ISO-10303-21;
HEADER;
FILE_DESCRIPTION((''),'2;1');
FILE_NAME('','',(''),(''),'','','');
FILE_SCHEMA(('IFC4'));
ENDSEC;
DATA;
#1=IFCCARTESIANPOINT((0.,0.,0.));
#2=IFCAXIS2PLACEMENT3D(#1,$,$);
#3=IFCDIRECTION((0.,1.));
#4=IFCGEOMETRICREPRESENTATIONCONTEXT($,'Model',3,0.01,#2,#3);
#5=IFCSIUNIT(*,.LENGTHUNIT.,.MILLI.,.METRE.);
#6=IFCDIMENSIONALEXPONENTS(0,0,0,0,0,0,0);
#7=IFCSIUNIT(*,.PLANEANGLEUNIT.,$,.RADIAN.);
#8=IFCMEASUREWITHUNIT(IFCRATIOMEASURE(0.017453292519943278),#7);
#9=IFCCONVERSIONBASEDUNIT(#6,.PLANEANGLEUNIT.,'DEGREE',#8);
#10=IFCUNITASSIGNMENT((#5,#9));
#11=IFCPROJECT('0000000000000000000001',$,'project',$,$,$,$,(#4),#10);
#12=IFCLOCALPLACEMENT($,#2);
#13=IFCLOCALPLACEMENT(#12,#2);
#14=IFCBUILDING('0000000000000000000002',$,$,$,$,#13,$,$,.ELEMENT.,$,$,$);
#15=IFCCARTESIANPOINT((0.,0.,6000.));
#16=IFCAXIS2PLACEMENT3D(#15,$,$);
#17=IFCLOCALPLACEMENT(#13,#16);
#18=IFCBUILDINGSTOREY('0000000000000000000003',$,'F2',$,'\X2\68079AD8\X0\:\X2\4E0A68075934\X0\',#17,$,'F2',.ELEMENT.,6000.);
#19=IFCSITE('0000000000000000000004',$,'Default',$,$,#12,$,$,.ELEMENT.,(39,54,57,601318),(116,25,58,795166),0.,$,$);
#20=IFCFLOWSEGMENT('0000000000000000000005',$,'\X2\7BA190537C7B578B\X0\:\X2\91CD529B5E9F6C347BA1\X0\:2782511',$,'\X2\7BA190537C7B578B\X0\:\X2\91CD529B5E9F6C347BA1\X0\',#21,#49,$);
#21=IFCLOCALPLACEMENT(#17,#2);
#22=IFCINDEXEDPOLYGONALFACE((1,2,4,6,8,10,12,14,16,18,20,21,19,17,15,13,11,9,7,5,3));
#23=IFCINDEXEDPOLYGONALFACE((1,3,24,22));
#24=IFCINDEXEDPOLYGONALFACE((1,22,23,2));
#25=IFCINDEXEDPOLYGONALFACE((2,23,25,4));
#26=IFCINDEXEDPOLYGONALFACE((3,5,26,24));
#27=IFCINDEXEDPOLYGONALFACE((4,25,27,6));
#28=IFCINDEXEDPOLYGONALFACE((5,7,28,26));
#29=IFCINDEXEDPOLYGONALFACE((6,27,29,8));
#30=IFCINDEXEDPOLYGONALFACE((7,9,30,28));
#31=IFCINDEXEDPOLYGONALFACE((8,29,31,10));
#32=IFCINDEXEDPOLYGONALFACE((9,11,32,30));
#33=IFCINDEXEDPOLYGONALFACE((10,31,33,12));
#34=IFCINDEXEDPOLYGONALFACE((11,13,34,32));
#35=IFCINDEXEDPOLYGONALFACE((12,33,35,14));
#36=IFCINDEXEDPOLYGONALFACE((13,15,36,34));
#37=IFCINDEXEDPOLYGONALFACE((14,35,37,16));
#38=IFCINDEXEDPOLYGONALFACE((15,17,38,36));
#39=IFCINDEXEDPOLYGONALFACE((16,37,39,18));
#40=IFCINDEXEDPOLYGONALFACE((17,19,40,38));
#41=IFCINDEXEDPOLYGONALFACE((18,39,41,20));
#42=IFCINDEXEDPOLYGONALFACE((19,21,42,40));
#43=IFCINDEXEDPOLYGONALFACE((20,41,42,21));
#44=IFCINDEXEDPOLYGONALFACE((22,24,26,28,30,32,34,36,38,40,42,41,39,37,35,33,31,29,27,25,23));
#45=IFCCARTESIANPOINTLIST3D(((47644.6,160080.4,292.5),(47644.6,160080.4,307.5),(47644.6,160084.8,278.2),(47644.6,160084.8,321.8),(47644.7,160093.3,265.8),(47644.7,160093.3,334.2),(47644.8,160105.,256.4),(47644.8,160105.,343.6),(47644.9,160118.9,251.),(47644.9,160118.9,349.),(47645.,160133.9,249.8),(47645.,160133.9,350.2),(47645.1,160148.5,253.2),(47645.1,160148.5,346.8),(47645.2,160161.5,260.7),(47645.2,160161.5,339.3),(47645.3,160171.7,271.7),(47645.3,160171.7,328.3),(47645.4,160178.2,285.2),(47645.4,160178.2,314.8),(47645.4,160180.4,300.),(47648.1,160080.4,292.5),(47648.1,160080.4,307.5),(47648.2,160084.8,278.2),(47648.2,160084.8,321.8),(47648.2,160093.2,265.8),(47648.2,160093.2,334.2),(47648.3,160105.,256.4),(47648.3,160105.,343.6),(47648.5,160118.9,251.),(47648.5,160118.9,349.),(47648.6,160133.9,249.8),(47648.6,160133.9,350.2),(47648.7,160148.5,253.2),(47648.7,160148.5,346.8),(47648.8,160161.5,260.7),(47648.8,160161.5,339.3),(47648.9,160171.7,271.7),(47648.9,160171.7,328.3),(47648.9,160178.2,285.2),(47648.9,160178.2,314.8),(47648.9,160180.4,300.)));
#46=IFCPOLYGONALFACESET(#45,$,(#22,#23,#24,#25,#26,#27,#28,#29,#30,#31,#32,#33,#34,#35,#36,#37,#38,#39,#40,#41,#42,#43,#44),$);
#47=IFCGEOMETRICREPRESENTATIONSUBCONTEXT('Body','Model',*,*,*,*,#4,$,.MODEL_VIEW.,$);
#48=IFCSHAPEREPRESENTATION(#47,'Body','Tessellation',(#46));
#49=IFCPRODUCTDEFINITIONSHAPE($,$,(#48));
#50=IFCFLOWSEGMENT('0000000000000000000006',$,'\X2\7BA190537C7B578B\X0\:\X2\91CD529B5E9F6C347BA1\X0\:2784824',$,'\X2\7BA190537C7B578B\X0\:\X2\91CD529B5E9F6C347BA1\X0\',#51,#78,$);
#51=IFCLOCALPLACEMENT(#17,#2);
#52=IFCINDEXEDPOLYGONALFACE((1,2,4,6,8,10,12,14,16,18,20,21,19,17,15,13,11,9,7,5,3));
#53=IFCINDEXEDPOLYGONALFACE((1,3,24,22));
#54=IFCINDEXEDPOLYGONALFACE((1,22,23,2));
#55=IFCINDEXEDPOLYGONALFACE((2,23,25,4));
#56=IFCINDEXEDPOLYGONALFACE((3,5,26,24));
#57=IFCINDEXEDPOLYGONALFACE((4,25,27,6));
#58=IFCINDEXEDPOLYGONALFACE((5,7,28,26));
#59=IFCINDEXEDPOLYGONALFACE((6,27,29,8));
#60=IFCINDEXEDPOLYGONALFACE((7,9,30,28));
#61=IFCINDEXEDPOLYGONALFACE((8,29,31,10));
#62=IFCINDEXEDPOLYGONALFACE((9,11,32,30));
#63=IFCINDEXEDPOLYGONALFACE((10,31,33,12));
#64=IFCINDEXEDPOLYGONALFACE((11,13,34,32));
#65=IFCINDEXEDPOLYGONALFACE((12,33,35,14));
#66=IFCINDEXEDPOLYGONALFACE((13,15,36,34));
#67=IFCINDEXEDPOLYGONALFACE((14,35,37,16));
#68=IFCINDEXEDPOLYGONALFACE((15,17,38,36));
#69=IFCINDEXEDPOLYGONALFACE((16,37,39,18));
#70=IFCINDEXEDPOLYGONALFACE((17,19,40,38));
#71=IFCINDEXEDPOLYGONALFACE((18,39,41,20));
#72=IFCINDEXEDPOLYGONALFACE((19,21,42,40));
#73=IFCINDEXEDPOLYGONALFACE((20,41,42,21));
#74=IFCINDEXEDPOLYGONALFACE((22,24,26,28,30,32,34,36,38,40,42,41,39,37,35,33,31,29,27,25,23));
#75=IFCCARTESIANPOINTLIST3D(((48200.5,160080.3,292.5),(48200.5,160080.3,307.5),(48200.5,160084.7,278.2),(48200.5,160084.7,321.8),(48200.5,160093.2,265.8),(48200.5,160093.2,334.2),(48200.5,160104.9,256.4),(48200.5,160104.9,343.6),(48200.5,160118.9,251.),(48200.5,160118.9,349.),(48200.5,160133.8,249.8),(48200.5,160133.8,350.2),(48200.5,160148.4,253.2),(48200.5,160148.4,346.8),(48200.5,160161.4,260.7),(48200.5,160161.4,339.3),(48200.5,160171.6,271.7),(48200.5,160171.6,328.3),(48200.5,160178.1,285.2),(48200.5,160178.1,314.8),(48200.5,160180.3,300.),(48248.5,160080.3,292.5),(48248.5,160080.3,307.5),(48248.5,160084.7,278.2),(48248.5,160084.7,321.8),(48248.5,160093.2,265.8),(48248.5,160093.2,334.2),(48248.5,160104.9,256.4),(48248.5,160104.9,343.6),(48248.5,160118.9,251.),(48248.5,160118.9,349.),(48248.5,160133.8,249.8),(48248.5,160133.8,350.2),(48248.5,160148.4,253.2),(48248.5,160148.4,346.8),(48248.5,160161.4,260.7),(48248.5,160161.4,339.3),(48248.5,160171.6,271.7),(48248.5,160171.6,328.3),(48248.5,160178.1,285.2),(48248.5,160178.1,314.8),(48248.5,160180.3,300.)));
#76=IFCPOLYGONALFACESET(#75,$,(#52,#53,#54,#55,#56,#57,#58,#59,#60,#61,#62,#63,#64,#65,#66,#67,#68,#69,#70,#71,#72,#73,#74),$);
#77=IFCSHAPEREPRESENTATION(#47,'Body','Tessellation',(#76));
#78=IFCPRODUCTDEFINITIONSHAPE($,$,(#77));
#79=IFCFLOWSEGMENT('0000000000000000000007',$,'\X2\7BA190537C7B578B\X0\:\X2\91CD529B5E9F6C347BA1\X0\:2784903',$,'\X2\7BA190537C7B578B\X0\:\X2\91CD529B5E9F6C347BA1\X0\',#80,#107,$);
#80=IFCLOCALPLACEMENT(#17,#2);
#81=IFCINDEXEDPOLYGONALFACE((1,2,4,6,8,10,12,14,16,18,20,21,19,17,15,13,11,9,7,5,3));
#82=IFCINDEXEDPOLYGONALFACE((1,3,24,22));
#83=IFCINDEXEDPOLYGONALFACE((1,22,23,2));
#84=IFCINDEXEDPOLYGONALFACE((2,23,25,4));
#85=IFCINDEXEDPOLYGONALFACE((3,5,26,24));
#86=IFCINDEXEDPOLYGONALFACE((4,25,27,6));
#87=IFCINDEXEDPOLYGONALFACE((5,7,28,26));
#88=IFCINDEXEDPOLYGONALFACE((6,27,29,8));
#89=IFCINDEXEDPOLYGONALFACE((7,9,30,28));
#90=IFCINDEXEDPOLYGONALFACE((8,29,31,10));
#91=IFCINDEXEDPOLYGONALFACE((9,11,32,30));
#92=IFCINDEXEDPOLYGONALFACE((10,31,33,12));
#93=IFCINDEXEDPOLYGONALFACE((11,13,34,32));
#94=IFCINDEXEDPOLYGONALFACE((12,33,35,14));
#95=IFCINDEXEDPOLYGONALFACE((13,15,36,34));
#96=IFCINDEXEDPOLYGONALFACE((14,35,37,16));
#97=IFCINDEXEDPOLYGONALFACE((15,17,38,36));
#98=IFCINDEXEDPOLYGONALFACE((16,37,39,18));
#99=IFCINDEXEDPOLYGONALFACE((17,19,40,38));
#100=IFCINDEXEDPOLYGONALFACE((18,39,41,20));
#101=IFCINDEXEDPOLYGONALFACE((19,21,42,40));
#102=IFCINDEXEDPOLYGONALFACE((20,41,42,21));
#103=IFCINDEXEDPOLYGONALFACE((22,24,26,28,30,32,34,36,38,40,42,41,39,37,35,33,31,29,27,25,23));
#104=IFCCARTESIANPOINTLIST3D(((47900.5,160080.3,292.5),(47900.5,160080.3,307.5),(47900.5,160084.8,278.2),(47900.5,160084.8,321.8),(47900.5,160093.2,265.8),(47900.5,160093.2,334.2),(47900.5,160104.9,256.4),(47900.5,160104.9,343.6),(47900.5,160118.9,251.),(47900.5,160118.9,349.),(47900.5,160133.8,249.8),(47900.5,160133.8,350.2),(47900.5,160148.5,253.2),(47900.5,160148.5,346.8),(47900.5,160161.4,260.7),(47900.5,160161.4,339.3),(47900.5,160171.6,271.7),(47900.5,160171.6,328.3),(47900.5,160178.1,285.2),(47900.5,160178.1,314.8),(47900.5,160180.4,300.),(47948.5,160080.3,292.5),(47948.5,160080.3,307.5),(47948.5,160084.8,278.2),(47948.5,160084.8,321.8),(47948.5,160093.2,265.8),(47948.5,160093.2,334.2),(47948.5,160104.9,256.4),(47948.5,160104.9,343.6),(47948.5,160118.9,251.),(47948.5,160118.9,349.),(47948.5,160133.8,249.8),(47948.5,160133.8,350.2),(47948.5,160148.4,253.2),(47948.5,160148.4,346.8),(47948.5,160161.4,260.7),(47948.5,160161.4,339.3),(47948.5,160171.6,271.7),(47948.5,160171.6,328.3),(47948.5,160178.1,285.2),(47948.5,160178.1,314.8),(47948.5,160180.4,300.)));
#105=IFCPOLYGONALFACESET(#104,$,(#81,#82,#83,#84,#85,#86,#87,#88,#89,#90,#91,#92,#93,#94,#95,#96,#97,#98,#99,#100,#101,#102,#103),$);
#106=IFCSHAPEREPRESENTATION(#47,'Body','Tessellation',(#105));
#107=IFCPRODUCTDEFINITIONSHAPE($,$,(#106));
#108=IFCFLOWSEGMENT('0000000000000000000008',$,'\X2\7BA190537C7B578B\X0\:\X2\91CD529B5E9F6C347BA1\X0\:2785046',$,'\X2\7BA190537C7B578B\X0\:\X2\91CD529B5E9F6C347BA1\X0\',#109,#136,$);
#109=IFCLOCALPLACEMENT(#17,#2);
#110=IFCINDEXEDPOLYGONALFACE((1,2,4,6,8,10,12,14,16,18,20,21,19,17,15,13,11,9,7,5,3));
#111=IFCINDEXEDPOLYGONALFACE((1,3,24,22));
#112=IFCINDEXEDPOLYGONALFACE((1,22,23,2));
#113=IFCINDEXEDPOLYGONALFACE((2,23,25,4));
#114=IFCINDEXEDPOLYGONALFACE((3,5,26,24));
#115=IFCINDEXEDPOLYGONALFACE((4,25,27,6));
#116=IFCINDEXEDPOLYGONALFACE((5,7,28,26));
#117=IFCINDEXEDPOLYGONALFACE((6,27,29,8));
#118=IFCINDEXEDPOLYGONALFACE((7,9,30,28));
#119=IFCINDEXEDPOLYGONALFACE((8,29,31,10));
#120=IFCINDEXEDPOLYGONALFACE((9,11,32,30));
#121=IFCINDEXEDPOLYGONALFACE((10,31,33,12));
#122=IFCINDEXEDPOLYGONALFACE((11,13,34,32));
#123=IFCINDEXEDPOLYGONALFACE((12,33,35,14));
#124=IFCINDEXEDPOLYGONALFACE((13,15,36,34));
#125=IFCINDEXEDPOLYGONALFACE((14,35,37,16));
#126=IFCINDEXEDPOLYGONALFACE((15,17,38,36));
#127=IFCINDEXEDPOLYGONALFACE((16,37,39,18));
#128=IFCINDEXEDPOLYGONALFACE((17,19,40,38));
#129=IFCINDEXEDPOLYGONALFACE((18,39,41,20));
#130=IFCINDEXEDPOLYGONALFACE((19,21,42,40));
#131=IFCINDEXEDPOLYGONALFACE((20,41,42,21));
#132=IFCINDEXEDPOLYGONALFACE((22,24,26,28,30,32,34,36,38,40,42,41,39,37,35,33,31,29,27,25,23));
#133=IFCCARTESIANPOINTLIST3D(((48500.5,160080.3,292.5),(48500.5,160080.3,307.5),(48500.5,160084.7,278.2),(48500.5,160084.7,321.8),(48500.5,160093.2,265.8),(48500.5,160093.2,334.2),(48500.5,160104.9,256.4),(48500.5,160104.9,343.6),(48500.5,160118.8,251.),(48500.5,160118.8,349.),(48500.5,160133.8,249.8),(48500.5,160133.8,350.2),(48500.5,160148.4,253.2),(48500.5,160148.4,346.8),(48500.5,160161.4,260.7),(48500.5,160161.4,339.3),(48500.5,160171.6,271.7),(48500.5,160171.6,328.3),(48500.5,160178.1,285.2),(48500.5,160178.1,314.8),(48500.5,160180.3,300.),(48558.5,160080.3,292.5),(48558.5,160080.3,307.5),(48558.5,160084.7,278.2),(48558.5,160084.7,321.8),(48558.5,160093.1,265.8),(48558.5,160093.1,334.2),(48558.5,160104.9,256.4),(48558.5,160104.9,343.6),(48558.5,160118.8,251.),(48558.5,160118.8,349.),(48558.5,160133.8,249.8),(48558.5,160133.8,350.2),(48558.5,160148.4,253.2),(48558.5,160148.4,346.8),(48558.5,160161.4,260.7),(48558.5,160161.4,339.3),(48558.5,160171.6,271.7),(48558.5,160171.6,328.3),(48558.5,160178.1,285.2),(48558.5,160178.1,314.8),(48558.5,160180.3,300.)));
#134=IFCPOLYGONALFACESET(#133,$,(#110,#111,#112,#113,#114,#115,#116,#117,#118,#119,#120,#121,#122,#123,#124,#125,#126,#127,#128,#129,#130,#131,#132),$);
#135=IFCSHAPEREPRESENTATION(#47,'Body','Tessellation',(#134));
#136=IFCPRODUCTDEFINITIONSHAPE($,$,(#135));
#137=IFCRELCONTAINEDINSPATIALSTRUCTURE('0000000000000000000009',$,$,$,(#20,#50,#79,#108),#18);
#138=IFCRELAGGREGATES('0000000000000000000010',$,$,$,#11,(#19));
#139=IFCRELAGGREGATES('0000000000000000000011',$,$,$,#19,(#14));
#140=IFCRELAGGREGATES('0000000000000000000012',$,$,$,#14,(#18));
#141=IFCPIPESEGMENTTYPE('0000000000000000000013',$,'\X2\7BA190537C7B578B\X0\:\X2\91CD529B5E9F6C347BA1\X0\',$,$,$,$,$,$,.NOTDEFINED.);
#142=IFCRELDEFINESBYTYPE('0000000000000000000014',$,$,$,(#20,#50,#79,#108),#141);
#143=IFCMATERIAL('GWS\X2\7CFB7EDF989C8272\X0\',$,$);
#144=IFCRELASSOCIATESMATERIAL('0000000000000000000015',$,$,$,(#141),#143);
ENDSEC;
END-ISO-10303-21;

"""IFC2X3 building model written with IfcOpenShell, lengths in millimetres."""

from ifc_helpers import new_model, entity, si_unit, converted_unit, direction, frame, origin, origin_2d_with_axis, place, context, subcontext, project, spatial, circle, extrude, material, type_object, element, save


model = new_model("IFC2X3")

# Units and contexts
model_context = context("Model", 3, precision=0.01, world=origin(), true_north=direction((0.0, 1.0)))
body_context = subcontext(model_context, "Body", "Model", "MODEL_VIEW")
ifc_project = project(units=[si_unit("LENGTHUNIT", "METRE", prefix="MILLI"), converted_unit("PLANEANGLEUNIT", "DEGREE", entity("IfcRatioMeasure", 0.017453292519943278), si_unit("PLANEANGLEUNIT", "RADIAN"), dimensions=[0, 0, 0, 0, 0, 0, 0])], contexts=[model_context])

# Site, building, storey
site_placement = place(None, origin())
site = spatial("IfcSite", under=ifc_project, at=site_placement, Name="Default", CompositionType="ELEMENT", RefLatitude=(39, 54, 57, 601318), RefLongitude=(116, 25, 58, 795166), RefElevation=0.0)
building_placement = place(site_placement, origin())
building = spatial("IfcBuilding", under=site, at=building_placement, CompositionType="ELEMENT")
storey_placement = place(building_placement, frame((0.0, 0.0, 6000.0)))
storey = spatial("IfcBuildingStorey", under=building, at=storey_placement, Name="F2", ObjectType="标高:上标头", LongName="F2", CompositionType="ELEMENT", Elevation=6000.0)

# Flow segments
ifc_material_1 = material(Name="GWS系统颜色")
pipe_segment_type_1 = type_object("IfcPipeSegmentType", Name="管道类型:重力废水管", PredefinedType="NOTDEFINED", material=ifc_material_1)
flow_segment_1_placement = place(storey_placement, origin())
element("IfcFlowSegment", 1, at=flow_segment_1_placement, inside=storey, type_object=pipe_segment_type_1, Name="管道类型:重力废水管:2782511", ObjectType="管道类型:重力废水管", context=body_context, shape_type="SweptSolid", body=[
    extrude(circle(Radius=50.3, at=origin_2d_with_axis()), frame((47648.5, 160130.1, 300.0), z_axis=(-0.999968, 0.007992, 0.0), x_axis=(0.007992, 0.999968, 0.0)), (0.0, 0.0, 1.0), 3.6),
])
flow_segment_2_placement = place(storey_placement, origin())
element("IfcFlowSegment", 2, at=flow_segment_2_placement, inside=storey, type_object=pipe_segment_type_1, Name="管道类型:重力废水管:2784824", ObjectType="管道类型:重力废水管", context=body_context, shape_type="SweptSolid", body=[
    extrude(circle(Radius=50.3, at=origin_2d_with_axis()), frame((48200.5, 160130.0, 300.0), z_axis=(1.0, -0.000102, 0.0), x_axis=(0.000102, 1.0, 0.0)), (0.0, 0.0, 1.0), 48.0),
])
flow_segment_3_placement = place(storey_placement, origin())
element("IfcFlowSegment", 3, at=flow_segment_3_placement, inside=storey, type_object=pipe_segment_type_1, Name="管道类型:重力废水管:2784903", ObjectType="管道类型:重力废水管", context=body_context, shape_type="SweptSolid", body=[
    extrude(circle(Radius=50.3, at=origin_2d_with_axis()), frame((47900.5, 160130.1, 300.0), z_axis=(1.0, -0.000102, 0.0), x_axis=(0.000102, 1.0, 0.0)), (0.0, 0.0, 1.0), 48.0),
])
flow_segment_4_placement = place(storey_placement, origin())
element("IfcFlowSegment", 4, at=flow_segment_4_placement, inside=storey, type_object=pipe_segment_type_1, Name="管道类型:重力废水管:2785046", ObjectType="管道类型:重力废水管", context=body_context, shape_type="SweptSolid", body=[
    extrude(circle(Radius=50.3, at=origin_2d_with_axis()), frame((48500.5, 160130.0, 300.0), z_axis=(1.0, -0.000102, 0.0), x_axis=(0.000102, 1.0, 0.0)), (0.0, 0.0, 1.0), 58.0),
])

save(model, "model.ifc")
